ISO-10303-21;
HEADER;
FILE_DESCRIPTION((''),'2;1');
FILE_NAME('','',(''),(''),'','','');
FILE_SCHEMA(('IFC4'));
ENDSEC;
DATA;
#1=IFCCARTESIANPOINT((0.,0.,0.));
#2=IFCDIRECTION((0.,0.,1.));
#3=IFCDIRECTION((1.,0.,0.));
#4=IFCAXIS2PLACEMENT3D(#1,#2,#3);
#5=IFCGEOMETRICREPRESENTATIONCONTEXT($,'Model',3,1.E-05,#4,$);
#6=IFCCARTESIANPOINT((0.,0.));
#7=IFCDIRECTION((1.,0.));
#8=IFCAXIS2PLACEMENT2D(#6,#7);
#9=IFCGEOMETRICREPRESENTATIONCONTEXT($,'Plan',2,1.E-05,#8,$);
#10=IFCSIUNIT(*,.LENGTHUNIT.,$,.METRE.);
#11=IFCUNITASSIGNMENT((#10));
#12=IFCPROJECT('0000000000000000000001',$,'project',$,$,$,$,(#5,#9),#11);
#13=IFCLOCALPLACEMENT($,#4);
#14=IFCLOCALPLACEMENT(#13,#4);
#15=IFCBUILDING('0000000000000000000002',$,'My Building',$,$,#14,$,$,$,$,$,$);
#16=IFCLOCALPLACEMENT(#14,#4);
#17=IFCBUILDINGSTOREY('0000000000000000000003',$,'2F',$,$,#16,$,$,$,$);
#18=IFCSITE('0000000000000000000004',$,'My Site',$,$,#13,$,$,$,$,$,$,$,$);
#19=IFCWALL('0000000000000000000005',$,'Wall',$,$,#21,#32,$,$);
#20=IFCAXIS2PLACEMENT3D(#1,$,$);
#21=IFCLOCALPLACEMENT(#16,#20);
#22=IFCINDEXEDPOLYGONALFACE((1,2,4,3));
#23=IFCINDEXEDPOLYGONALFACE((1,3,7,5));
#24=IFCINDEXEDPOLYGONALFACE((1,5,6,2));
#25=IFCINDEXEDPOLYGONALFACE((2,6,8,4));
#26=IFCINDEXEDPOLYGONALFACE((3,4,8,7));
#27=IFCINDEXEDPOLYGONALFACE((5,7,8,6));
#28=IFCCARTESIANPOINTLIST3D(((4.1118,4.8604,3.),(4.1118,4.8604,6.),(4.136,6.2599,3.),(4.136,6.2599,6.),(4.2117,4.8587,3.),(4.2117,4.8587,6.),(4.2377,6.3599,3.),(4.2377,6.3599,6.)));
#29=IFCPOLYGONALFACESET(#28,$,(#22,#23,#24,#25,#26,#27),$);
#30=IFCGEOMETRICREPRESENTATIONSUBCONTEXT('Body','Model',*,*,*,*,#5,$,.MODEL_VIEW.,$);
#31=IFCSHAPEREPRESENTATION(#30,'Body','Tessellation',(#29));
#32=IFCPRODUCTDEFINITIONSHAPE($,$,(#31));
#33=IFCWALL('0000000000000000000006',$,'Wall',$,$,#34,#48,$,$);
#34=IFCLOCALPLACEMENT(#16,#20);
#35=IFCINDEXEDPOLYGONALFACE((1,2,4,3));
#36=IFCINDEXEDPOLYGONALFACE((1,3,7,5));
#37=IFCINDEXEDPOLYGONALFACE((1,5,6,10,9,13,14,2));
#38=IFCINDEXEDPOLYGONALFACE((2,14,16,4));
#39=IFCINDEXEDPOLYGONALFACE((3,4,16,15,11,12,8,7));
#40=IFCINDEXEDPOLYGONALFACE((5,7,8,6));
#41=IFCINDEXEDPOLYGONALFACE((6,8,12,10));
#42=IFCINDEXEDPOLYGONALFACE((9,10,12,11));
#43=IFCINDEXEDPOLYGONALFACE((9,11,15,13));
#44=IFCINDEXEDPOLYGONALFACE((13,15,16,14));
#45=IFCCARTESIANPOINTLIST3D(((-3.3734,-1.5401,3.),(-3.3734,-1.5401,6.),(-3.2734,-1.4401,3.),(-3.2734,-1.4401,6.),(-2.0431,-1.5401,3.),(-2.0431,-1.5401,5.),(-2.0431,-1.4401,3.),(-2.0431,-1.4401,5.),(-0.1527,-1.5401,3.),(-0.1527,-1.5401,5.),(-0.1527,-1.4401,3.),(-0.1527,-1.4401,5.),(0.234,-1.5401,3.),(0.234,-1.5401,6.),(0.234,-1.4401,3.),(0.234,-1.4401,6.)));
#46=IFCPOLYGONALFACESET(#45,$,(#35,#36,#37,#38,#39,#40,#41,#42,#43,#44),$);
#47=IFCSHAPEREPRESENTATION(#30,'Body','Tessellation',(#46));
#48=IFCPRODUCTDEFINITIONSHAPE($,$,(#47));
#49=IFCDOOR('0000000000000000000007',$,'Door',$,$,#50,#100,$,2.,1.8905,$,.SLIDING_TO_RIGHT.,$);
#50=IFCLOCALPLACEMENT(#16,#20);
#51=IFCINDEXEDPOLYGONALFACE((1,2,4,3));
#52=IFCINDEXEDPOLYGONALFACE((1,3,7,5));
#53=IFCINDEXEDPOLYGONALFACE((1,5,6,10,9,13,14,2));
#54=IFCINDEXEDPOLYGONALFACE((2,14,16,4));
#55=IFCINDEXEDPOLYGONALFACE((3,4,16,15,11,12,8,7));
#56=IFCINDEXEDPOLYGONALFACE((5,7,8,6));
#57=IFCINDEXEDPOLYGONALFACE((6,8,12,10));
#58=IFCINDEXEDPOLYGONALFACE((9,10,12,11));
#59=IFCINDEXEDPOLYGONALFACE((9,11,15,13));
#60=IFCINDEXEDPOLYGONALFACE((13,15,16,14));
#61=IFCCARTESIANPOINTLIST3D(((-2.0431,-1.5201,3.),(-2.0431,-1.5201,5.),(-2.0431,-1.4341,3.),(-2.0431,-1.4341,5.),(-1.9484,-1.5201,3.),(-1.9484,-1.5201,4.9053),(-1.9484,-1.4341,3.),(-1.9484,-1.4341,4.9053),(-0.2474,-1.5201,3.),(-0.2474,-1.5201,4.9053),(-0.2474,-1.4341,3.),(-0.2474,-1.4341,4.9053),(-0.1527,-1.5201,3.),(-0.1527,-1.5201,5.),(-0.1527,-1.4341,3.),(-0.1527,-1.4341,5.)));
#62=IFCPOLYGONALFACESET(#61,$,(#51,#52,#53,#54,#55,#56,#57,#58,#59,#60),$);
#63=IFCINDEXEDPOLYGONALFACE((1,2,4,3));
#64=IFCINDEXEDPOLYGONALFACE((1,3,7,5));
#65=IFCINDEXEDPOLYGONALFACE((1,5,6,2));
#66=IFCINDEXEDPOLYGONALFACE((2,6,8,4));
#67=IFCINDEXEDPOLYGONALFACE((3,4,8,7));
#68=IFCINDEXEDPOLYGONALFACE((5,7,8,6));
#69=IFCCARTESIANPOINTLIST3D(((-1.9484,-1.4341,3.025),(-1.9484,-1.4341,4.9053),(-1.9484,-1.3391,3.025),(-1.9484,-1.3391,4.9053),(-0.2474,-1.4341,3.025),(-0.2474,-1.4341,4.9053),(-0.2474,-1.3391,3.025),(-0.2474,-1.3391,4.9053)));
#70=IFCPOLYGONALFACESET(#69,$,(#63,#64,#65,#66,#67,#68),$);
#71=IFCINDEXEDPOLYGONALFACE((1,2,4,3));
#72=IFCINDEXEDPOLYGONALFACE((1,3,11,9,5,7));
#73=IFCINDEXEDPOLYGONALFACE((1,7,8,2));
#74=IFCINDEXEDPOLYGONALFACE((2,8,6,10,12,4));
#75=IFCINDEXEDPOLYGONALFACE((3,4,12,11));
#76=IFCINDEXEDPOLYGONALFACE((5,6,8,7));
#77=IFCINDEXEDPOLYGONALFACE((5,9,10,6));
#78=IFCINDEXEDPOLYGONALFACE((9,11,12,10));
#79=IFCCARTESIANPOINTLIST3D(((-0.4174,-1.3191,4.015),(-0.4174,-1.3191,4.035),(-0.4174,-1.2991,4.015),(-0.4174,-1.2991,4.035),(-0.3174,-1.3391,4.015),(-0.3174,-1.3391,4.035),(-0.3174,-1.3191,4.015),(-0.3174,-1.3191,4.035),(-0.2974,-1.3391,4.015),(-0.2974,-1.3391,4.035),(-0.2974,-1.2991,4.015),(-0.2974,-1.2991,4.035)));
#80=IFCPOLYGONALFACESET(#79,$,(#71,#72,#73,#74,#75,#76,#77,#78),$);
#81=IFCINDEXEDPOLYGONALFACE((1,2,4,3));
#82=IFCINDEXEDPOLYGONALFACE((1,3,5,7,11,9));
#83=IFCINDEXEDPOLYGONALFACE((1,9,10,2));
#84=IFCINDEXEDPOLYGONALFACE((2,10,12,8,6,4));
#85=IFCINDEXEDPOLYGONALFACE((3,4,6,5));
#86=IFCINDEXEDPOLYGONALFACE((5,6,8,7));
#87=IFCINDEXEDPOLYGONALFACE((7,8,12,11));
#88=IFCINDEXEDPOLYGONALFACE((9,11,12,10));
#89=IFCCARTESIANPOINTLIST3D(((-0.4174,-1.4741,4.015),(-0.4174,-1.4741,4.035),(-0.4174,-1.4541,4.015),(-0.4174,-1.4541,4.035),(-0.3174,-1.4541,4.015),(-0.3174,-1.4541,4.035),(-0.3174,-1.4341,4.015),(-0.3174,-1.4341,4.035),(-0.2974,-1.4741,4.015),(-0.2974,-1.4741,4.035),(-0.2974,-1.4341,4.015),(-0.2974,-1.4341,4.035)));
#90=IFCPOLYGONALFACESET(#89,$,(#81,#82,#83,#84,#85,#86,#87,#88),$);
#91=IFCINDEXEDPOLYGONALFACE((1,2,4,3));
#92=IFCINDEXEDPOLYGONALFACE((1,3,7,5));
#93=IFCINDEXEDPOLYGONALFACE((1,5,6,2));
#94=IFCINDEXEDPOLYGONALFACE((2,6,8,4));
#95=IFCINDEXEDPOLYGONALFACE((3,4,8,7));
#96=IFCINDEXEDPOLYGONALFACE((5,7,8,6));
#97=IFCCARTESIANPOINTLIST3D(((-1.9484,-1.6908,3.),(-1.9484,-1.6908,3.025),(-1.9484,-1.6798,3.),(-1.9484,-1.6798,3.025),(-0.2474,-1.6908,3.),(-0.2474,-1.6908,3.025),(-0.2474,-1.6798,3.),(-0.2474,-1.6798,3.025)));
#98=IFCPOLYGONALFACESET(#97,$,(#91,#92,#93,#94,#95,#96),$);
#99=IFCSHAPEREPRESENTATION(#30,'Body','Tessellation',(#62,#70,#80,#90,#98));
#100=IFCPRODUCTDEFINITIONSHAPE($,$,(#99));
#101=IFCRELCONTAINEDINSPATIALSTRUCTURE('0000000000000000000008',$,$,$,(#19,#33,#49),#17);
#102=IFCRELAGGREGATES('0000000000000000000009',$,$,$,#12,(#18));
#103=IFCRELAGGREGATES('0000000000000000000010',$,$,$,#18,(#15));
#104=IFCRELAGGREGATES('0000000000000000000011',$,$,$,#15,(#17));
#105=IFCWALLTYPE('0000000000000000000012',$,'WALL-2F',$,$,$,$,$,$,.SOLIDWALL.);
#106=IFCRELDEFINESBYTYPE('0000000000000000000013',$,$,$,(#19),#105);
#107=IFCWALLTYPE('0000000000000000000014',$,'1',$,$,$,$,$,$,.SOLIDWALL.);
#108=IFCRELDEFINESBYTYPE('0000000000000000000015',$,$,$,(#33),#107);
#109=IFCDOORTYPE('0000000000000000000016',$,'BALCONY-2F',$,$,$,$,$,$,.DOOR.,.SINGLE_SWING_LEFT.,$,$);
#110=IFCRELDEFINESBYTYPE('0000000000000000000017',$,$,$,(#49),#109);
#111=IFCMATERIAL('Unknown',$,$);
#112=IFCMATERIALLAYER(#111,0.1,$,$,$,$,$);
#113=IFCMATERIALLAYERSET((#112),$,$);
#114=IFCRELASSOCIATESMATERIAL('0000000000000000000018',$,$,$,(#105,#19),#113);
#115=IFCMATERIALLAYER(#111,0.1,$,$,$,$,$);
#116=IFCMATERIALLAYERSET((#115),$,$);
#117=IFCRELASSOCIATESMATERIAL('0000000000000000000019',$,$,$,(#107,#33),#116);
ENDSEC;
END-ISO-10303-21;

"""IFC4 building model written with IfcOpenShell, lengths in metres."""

from ifc_helpers import new_model, entity, si_unit, frame, origin_with_axes, origin_2d_with_axis, place, context, subcontext, project, spatial, line, indexed_curve, outline, extrude, shape, source, transform, mapped, material, layer, layer_set, layer_usage, type_object, type_shapes, element, fill, save


model = new_model("IFC4")

# Units and contexts
model_context = context("Model", 3, precision=1e-05, world=origin_with_axes())
plan_context = context("Plan", 2, precision=1e-05, world=origin_2d_with_axis())
body_context_1 = subcontext(model_context, "Body", "Model", "MODEL_VIEW")
body_context_2 = subcontext(plan_context, "Body", "Plan", "PLAN_VIEW")
ifc_project = project(units=[si_unit("LENGTHUNIT", "METRE")], contexts=[model_context, plan_context])

# Site, building, storey
site_placement = place(None, origin_with_axes())
site = spatial("IfcSite", under=ifc_project, at=site_placement, Name="My Site")
building_placement = place(site_placement, origin_with_axes())
building = spatial("IfcBuilding", under=site, at=building_placement, Name="My Building")
storey_placement = place(building_placement, origin_with_axes())
storey = spatial("IfcBuildingStorey", under=building, at=storey_placement, Name="2F")

# Shared definitions
ifc_material = material(Name="Unknown")
ifc_layer_1 = layer(ifc_material, 0.1)
ifc_layer_set_1 = layer_set([ifc_layer_1])
wall_type_1 = type_object("IfcWallType", Name="WALL-2F", PredefinedType="SOLIDWALL", material=ifc_layer_set_1)

# Wall
ifc_layer_usage_1 = layer_usage(ifc_layer_set_1, "AXIS2", "POSITIVE", 0.0)
wall_1_placement = place(storey_placement, frame((4.2117, 4.8587, 3.0), z_axis=(0.0, 0.0, 1.0), x_axis=(0.0173, 0.99985, 0.0)))
element("IfcWall", 1, at=wall_1_placement, inside=storey, type_object=wall_type_1, material=ifc_layer_usage_1, Name="Wall", context=body_context_1, shape_type="SweptSolid", body=[
    extrude(outline(indexed_curve([(0.0, 0.0), (0.0, 0.1), (1.3997, 0.1), (1.5015, 0.0)], segments=[line(1, 2, 3, 4, 1)])), origin_with_axes(), (0.0, 0.0, 1.0), 3.0),
])

# Wall, opening, door
ifc_layer_2 = layer(ifc_material, 0.1)
ifc_layer_set_2 = layer_set([ifc_layer_2])
ifc_layer_usage_2 = layer_usage(ifc_layer_set_2, "AXIS2", "POSITIVE", 0.0)
wall_type_2 = type_object("IfcWallType", Name="1", PredefinedType="SOLIDWALL", material=ifc_layer_set_2)
wall_2_placement = place(storey_placement, frame((-3.3734, -1.5401, 3.0), z_axis=(0.0, 0.0, 1.0), x_axis=(1.0, 0.0, 0.0)))
wall_2 = element("IfcWall", 2, at=wall_2_placement, inside=storey, type_object=wall_type_2, material=ifc_layer_usage_2, Name="Wall", context=body_context_1, shape_type="SweptSolid", body=[
    extrude(outline(indexed_curve([(0.0, 0.0), (0.1, 0.1), (3.6074, 0.1), (3.6074, 0.0)], segments=[line(1, 2, 3, 4, 1)])), origin_with_axes(), (0.0, 0.0, 1.0), 3.0),
])
shared_shape_1 = source(origin_with_axes(), body_context_1, "Body", "SweptSolid", [
    extrude(outline(indexed_curve([(0.0, 0.0), (1.8905, 0.0), (1.8905, 2.0), (0.0, 2.0)], segments=[line(1, 2, 3, 4, 1)])), frame((0.0, -0.6, 0.0), z_axis=(0.0, -1.0, 0.0), x_axis=(1.0, 0.0, 0.0)), (0.0, 0.0, -1.0), 1.2),
])
opening_1_placement = place(wall_2_placement, frame((1.3303, 0.0, 0.0), z_axis=(0.0, 0.0, 1.0), x_axis=(1.0, 0.0, 0.0)))
opening_1 = element("IfcOpeningElement", 3, at=opening_1_placement, cuts=wall_2, PredefinedType="OPENING", context=body_context_1, shape_type="MappedRepresentation", body=[
    mapped(shared_shape_1, transform((0.0, 0.0, 0.0), x_axis=(1.0, 0.0, 0.0), y_axis=(0.0, 1.0, 0.0), z_axis=(0.0, 0.0, 1.0), scale=1.0)),
])
door_type_1 = type_object("IfcDoorType", Name="BALCONY-2F", OperationType="SINGLE_SWING_LEFT", PredefinedType="DOOR")
shared_shape_2 = source(origin_with_axes(), body_context_1, "Body", "SweptSolid", [
    extrude(outline(indexed_curve([(0.0, 0.0), (0.0, 2.0), (1.8905, 2.0), (1.8905, 0.0), (1.7957, 0.0), (1.7957, 1.9053), (0.0947, 1.9053), (0.0947, 0.0)], segments=[line(1, 2, 3, 4, 5, 6, 7, 8, 1)])), frame((0.0, -0.0157, 0.0), z_axis=(0.0, -1.0, 0.0), x_axis=(1.0, 0.0, 0.0)), (0.0, 0.0, -1.0), 0.086),
    extrude(outline(indexed_curve([(0.0, 0.0), (1.701, 0.0), (1.701, 0.095), (0.0, 0.095)], segments=[line(1, 2, 3, 4, 1)])), frame((0.0947, -0.1107, 0.025), z_axis=(0.0, 0.0, 1.0), x_axis=(1.0, 0.0, 0.0)), (0.0, 0.0, 1.0), 1.8803),
    extrude(outline(indexed_curve([(0.0, 0.0), (0.0, -0.04), (0.12, -0.04), (0.12, -0.02), (0.02, -0.02), (0.02, 0.0)], segments=[line(1, 2, 3, 4, 5, 6, 1)])), frame((0.1447, -0.1107, 1.015), z_axis=(0.0, 0.0, 1.0), x_axis=(1.0, 0.0, 0.0)), (0.0, 0.0, 1.0), 0.02),
    extrude(outline(indexed_curve([(0.0, 0.0), (0.0, 0.04), (0.12, 0.04), (0.12, 0.02), (0.02, 0.02), (0.02, 0.0)], segments=[line(1, 2, 3, 4, 5, 6, 1)])), frame((0.1447, -0.0157, 1.015), z_axis=(0.0, 0.0, 1.0), x_axis=(1.0, 0.0, 0.0)), (0.0, 0.0, 1.0), 0.02),
    extrude(outline(indexed_curve([(0.0, 0.0), (1.701, 0.0), (1.701, 0.011), (0.0, 0.011)], segments=[line(1, 2, 3, 4, 1)])), frame((0.0947, 0.23, 0.0), z_axis=(0.0, 0.0, 1.0), x_axis=(1.0, 0.0, 0.0)), (0.0, 0.0, 1.0), 0.025),
])
shared_shape_3 = source(origin_with_axes(), body_context_2, "Body", "Curve2D", [
    entity("IfcIndexedPolyCurve", entity("IfcCartesianPointList2D", [[0.0, -0.0157], [0.0947, -0.0157], [0.0947, 0.0703], [0.0, 0.0703]]), [entity("IfcLineIndex", [1, 2, 3, 4, 1])]),
    entity("IfcIndexedPolyCurve", entity("IfcCartesianPointList2D", [[1.8905, -0.0157], [1.7957, -0.0157], [1.7957, 0.0703], [1.8905, 0.0703]]), [entity("IfcLineIndex", [1, 2, 3, 4, 1])]),
    entity("IfcIndexedPolyCurve", entity("IfcCartesianPointList2D", [[2.6462, -0.1107], [0.9452, -0.1107], [0.9452, -0.0157], [2.6462, -0.0157]]), [entity("IfcLineIndex", [1, 2, 3, 4, 1])]),
])
type_shapes(door_type_1, [shared_shape_2, shared_shape_3])
door_1_placement = place(opening_1_placement, frame((1.8905, 0.0903, 0.0), z_axis=(0.0, 0.0, 1.0), x_axis=(-1.0, 0.0, 0.0)))
door_1 = element("IfcDoor", 4, at=door_1_placement, inside=storey, type_object=door_type_1, Name="Door", OperationType="SLIDING_TO_RIGHT", OverallHeight=2.0, OverallWidth=1.8905, shapes=[
    shape(body_context_1, "Body", "MappedRepresentation", [mapped(shared_shape_2, transform((0.0, 0.0, 0.0), x_axis=(1.0, 0.0, 0.0), y_axis=(0.0, 1.0, 0.0), z_axis=(0.0, 0.0, 1.0), scale=1.0))]),
    shape(body_context_2, "Body", "MappedRepresentation", [mapped(shared_shape_3, transform((0.0, 0.0, 0.0), x_axis=(1.0, 0.0, 0.0), y_axis=(0.0, 1.0, 0.0), z_axis=(0.0, 0.0, 1.0), scale=1.0))]),
])
fill(opening_1, door_1)

save(model, "model.ifc")
